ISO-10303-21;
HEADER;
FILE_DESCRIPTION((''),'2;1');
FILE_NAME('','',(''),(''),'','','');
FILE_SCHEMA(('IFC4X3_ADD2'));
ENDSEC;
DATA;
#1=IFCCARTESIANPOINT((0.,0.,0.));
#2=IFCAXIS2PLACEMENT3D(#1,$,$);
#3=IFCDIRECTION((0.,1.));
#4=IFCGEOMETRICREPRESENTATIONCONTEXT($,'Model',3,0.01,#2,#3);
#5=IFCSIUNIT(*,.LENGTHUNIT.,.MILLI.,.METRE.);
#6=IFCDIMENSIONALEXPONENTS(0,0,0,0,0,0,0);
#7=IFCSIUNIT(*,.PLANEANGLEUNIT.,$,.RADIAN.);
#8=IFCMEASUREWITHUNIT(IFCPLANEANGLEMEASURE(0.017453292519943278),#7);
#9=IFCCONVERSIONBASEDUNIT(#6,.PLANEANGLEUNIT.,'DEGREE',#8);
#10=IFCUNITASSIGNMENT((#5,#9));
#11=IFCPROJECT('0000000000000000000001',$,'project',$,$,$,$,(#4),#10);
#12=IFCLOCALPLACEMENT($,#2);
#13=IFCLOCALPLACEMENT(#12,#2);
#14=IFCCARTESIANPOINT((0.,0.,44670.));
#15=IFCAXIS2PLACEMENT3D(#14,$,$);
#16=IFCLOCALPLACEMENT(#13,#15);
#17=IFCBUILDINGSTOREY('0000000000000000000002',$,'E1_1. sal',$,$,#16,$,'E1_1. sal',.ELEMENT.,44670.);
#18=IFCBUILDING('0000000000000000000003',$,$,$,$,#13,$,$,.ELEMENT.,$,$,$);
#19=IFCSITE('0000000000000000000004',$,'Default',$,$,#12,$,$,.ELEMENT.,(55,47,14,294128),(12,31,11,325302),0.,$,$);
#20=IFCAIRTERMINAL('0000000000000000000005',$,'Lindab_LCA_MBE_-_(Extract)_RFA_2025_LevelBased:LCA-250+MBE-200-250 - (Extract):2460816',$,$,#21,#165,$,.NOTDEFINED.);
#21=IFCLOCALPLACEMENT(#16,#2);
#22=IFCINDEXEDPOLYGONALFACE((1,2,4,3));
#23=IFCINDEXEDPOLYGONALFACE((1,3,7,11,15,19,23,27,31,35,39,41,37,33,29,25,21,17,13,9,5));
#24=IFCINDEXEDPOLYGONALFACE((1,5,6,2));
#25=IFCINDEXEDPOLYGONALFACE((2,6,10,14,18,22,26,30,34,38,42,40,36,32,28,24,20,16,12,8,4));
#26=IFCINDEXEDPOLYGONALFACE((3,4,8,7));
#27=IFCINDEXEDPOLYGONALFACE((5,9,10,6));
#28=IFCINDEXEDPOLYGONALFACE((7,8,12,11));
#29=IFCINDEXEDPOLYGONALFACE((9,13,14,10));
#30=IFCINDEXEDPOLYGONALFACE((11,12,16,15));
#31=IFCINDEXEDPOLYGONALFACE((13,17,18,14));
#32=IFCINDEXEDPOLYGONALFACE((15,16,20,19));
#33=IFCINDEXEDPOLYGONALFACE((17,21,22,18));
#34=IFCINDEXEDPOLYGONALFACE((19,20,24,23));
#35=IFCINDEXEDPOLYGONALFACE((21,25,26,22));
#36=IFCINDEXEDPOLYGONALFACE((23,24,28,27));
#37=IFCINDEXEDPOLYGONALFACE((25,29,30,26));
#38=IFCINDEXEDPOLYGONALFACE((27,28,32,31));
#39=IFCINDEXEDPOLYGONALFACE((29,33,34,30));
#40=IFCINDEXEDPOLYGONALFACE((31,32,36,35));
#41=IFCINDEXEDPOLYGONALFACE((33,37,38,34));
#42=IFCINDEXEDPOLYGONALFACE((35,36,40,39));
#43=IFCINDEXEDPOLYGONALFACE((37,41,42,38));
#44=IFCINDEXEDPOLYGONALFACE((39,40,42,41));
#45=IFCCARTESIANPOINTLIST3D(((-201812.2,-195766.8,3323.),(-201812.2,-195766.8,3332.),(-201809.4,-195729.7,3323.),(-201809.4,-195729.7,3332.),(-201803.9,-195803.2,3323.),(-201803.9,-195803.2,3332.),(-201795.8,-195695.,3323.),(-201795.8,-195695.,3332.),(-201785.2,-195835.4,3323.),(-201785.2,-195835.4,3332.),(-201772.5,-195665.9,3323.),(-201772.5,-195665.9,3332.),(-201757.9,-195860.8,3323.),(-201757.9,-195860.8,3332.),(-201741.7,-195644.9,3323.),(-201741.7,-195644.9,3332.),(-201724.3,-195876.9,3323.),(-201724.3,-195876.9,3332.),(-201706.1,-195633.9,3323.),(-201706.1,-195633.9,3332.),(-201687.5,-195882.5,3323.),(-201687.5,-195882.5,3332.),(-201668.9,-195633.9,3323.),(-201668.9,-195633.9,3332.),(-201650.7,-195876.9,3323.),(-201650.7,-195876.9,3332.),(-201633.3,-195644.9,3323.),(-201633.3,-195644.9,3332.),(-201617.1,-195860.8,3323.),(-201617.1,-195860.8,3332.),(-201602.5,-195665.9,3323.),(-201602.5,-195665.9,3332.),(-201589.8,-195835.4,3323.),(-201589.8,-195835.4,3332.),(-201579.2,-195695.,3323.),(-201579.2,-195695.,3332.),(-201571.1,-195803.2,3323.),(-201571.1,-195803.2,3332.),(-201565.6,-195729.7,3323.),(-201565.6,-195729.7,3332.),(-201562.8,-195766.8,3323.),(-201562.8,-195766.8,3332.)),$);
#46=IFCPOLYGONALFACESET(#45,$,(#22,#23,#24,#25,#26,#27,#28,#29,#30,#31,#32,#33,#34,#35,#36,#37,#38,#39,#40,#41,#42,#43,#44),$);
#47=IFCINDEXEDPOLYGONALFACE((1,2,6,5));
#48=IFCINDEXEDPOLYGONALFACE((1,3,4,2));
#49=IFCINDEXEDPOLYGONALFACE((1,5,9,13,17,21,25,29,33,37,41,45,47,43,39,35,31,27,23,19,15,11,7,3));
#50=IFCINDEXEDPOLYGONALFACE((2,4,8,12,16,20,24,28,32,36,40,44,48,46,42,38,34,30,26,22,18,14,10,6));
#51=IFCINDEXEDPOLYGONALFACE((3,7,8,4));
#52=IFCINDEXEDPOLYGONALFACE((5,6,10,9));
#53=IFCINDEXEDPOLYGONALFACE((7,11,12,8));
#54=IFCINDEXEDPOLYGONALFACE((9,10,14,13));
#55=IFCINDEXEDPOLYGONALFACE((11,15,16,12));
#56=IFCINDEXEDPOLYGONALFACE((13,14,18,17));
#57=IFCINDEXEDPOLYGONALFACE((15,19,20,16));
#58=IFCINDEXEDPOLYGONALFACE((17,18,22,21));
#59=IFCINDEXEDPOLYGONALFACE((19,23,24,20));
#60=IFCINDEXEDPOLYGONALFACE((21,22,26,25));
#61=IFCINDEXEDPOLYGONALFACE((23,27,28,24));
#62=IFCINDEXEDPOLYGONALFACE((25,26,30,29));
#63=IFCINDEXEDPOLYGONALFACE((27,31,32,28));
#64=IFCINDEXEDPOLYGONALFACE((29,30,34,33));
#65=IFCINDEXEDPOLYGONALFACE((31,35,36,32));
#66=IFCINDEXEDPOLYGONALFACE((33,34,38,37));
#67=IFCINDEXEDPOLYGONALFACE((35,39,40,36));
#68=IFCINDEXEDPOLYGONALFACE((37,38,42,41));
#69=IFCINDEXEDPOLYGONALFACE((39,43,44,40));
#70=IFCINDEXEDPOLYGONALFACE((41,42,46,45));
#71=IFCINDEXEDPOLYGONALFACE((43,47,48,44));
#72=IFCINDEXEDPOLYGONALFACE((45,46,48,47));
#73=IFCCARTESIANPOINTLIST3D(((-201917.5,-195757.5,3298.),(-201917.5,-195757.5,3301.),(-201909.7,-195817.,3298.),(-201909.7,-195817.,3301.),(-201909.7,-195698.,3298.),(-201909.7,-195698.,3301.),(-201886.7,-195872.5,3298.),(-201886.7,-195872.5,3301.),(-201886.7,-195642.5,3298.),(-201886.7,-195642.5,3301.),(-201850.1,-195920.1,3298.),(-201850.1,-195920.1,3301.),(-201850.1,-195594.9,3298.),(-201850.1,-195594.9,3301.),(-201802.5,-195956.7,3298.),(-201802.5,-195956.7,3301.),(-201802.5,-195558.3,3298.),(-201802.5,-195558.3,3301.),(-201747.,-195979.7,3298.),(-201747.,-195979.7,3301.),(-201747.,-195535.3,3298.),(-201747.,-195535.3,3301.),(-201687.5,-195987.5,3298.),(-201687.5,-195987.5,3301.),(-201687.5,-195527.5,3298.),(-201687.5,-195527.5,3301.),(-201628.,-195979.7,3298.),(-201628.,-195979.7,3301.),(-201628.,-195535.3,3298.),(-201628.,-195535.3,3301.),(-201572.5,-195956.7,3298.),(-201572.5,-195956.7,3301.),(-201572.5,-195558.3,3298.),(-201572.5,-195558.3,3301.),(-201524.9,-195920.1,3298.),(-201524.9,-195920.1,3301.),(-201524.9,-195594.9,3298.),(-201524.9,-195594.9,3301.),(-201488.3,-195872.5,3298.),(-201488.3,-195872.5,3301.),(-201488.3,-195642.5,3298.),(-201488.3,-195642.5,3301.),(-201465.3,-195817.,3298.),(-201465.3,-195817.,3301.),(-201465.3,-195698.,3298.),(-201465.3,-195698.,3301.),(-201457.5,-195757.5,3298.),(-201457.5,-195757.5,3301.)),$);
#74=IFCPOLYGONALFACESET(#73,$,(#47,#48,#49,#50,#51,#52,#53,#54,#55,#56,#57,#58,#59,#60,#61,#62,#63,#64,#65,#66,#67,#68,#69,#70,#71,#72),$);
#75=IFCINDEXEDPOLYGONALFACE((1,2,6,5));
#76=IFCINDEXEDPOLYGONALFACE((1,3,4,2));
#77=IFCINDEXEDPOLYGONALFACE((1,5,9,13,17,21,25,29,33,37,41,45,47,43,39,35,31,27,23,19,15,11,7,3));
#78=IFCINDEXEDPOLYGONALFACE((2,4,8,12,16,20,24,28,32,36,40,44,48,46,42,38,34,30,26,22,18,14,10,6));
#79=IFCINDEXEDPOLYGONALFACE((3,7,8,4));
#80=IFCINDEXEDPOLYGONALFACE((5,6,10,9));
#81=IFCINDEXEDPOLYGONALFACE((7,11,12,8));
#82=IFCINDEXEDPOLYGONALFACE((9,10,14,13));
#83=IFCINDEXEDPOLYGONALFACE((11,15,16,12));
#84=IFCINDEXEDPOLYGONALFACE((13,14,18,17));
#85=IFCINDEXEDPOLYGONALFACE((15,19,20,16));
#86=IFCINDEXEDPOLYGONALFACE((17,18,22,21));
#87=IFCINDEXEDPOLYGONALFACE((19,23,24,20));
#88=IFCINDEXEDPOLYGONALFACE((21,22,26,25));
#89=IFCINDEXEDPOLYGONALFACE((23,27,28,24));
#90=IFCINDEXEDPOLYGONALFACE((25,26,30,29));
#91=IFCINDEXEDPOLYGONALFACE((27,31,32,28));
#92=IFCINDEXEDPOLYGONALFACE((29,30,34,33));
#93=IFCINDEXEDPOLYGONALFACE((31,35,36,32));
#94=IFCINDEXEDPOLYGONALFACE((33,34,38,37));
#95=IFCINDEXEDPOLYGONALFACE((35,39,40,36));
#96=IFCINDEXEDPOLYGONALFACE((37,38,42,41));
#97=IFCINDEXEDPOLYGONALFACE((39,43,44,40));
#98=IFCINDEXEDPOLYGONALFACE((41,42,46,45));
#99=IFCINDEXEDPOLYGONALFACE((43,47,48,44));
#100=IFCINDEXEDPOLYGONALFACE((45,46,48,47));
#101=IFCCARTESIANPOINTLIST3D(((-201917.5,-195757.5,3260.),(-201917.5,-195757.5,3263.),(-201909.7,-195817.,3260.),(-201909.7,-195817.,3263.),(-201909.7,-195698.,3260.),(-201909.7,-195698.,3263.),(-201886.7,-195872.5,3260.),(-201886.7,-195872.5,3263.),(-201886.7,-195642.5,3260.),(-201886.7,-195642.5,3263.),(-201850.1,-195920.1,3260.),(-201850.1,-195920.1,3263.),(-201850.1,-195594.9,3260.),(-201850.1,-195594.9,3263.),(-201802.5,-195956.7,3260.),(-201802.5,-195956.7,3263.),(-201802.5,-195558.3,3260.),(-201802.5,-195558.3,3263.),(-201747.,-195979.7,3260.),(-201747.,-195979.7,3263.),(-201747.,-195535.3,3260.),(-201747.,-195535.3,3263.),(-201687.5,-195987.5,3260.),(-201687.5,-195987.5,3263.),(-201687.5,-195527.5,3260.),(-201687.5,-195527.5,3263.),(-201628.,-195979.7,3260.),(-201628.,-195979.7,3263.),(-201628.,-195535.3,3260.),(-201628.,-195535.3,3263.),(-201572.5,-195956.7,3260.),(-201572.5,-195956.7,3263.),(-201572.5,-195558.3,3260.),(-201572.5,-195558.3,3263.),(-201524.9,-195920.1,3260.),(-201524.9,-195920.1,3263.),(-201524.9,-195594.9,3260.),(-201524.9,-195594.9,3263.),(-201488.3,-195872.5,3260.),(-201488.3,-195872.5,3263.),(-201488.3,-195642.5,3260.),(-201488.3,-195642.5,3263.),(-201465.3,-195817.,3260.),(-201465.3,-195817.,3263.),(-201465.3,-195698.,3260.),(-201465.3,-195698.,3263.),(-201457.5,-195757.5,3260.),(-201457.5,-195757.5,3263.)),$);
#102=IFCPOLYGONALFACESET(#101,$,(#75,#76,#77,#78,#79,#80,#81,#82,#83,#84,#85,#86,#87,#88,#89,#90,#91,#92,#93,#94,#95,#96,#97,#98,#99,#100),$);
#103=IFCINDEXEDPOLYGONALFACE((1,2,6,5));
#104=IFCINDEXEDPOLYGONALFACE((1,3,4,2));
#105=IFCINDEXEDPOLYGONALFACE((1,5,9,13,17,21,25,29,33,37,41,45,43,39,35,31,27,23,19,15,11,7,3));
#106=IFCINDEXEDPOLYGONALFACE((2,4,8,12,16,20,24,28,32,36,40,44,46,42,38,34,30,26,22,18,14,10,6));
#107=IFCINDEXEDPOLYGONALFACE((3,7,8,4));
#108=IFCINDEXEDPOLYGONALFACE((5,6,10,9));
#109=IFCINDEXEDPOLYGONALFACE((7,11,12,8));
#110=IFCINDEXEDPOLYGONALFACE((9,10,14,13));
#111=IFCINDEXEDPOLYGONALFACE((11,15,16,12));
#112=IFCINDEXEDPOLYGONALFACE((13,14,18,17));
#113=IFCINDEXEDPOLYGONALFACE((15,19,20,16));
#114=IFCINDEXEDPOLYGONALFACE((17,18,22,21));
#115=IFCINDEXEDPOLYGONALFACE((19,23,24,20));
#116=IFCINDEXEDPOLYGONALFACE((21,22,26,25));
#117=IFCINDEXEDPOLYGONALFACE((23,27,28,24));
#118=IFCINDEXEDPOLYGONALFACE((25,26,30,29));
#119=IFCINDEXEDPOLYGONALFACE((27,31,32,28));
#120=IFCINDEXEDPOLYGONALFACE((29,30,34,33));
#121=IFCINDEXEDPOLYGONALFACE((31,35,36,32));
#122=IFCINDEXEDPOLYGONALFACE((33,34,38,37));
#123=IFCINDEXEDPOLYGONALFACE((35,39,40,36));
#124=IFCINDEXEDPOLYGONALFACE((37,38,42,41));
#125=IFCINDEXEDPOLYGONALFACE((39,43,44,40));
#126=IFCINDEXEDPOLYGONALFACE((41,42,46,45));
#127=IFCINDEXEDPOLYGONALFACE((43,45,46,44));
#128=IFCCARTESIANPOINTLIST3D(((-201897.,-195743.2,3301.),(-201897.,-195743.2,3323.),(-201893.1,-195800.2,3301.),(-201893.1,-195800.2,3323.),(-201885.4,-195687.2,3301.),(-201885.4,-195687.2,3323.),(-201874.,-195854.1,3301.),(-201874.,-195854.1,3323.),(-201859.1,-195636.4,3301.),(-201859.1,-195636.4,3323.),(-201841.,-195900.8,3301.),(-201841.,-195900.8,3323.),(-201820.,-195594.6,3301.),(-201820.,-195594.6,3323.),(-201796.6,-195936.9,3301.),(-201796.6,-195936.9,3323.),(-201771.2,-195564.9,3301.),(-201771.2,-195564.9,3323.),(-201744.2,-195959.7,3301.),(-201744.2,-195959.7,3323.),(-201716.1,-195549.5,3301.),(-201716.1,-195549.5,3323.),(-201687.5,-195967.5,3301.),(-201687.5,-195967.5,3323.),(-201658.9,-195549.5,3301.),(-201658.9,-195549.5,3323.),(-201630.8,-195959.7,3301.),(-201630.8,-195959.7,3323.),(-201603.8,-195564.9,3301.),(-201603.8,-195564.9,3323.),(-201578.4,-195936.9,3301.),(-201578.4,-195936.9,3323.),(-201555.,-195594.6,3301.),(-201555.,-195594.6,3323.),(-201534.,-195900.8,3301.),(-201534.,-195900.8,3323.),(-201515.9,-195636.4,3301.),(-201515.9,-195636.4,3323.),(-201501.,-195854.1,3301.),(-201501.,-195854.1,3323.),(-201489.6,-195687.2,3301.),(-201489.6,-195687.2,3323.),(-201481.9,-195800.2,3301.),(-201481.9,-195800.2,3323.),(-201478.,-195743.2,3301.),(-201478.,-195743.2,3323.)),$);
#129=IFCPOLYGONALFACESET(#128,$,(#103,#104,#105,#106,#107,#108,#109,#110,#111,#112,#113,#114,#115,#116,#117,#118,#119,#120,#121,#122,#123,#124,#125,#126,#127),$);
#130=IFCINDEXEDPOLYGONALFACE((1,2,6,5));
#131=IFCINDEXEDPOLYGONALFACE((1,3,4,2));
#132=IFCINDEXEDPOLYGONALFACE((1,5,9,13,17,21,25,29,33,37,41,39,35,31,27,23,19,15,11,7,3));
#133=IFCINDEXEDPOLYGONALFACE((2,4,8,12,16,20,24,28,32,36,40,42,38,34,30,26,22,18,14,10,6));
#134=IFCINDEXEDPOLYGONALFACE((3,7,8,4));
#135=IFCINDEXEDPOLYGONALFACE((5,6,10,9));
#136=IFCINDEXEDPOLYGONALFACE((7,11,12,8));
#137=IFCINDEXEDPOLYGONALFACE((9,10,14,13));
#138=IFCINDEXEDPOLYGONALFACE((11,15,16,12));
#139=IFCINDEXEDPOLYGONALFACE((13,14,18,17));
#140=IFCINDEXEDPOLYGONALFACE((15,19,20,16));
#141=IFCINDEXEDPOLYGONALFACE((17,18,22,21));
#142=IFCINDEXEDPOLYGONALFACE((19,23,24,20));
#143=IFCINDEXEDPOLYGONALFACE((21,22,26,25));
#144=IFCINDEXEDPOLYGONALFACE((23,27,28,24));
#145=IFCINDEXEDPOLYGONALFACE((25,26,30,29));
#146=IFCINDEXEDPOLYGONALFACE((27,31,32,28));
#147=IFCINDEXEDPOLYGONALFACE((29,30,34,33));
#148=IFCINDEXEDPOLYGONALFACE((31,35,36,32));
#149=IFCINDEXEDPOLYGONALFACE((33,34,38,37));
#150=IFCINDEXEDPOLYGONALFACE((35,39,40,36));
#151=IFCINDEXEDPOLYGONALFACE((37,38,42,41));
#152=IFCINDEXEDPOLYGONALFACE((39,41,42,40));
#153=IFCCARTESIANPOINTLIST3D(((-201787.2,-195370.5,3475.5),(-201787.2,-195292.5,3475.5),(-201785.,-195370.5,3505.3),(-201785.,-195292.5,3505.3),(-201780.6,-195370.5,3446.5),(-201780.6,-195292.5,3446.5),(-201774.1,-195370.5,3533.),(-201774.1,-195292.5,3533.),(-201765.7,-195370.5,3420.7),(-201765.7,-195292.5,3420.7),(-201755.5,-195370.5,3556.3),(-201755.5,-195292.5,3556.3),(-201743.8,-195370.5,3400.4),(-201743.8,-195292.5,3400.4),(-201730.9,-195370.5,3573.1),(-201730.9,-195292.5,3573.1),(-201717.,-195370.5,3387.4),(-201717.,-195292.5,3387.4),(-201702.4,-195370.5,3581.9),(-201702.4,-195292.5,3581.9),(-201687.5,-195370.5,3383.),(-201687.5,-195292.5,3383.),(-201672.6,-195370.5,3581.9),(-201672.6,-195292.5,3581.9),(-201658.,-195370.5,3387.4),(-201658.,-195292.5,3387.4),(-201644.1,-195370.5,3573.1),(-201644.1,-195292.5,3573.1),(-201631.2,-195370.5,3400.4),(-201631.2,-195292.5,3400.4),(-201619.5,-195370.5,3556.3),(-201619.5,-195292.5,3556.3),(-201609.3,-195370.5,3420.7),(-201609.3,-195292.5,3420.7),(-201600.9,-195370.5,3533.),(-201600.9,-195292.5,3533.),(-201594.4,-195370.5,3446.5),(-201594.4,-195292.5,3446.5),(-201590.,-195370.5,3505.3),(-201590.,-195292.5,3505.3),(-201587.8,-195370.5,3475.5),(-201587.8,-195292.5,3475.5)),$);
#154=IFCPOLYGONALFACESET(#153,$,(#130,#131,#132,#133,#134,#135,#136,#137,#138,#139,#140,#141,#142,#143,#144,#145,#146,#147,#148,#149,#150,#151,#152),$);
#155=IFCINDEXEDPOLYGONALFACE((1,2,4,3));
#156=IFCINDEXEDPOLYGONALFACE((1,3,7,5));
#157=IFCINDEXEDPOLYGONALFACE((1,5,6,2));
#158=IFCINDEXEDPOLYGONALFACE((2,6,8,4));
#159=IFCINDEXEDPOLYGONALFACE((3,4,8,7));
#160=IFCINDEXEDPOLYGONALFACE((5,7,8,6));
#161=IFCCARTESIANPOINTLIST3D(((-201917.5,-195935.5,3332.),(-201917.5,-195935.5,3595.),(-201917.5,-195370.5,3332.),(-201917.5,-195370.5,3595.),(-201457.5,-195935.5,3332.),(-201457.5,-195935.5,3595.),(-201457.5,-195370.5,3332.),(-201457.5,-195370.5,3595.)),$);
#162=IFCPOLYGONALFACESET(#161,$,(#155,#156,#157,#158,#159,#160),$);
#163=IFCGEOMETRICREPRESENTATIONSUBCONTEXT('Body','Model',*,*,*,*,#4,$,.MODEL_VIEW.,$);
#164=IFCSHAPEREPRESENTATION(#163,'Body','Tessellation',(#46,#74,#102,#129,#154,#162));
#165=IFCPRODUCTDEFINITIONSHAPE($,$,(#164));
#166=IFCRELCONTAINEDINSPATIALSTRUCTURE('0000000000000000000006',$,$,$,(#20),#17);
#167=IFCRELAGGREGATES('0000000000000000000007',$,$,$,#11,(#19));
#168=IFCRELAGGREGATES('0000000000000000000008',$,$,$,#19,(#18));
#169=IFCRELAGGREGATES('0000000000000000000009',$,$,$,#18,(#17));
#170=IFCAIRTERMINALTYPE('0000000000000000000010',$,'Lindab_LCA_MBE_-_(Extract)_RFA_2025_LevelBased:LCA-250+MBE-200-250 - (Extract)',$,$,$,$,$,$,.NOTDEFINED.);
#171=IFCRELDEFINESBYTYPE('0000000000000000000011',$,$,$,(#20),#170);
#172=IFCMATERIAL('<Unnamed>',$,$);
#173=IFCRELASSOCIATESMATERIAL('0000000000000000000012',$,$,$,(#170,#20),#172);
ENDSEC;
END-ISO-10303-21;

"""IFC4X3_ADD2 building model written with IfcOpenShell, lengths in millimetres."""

from ifc_helpers import new_model, entity, si_unit, converted_unit, direction, frame, frame_2d, origin, origin_2d_with_axis, place, context, subcontext, project, spatial, rectangle, circle, extrude, source, transform, mapped, material, type_object, type_shapes, element, save


model = new_model("IFC4X3_ADD2")

# Units and contexts
model_context = context("Model", 3, precision=0.01, world=origin(), true_north=direction((0.0, 1.0)))
body_context = subcontext(model_context, "Body", "Model", "MODEL_VIEW")
ifc_project = project(units=[si_unit("LENGTHUNIT", "METRE", prefix="MILLI"), converted_unit("PLANEANGLEUNIT", "DEGREE", entity("IfcPlaneAngleMeasure", 0.017453292519943278), si_unit("PLANEANGLEUNIT", "RADIAN"), dimensions=[0, 0, 0, 0, 0, 0, 0])], contexts=[model_context])

# Site, building, storey
site_placement = place(None, origin())
site = spatial("IfcSite", under=ifc_project, at=site_placement, Name="Default", CompositionType="ELEMENT", RefLatitude=(55, 47, 14, 294128), RefLongitude=(12, 31, 11, 325302), RefElevation=0.0)
building_placement = place(site_placement, origin())
building = spatial("IfcBuilding", under=site, at=building_placement, CompositionType="ELEMENT")
storey_placement = place(building_placement, frame((0.0, 0.0, 44670.0)))
storey = spatial("IfcBuildingStorey", under=building, at=storey_placement, Name="E1_1. sal", LongName="E1_1. sal", CompositionType="ELEMENT", Elevation=44670.0)

# Air terminal
ifc_material_1 = material(Name="<Unnamed>")
air_terminal_type = type_object("IfcAirTerminalType", Name="Lindab_LCA_MBE_-_(Extract)_RFA_2025_LevelBased:LCA-250+MBE-200-250 - (Extract)", PredefinedType="NOTDEFINED", material=ifc_material_1)
shared_shape_1 = source(origin(), body_context, "Body", "SweptSolid", [
    extrude(circle(Radius=125.0, at=frame_2d((0.0, 0.0), x_axis=(1.0, 0.0))), frame((0.0, 0.0, 22.0)), (0.0, 0.0, 1.0), 9.0),
    extrude(circle(Radius=230.0, at=frame_2d((0.0, 0.0), x_axis=(1.0, 0.0))), frame((0.0, 0.0, -3.0)), (0.0, 0.0, 1.0), 3.0),
    extrude(circle(Radius=230.0, at=frame_2d((0.0, 0.0), x_axis=(1.0, 0.0))), frame((0.0, 0.0, -41.0)), (0.0, 0.0, 1.0), 3.0),
    extrude(circle(Radius=210.0, at=frame_2d((0.0, 0.0), x_axis=(1.0, 0.0))), origin(), (0.0, 0.0, 1.0), 22.0),
    extrude(circle(Radius=100.0, at=frame_2d((0.0, 0.0), x_axis=(1.0, 0.0))), frame((-465.0, 0.0, 182.0), z_axis=(1.0, 0.0, 0.0), x_axis=(0.0, 0.0, -1.0)), (0.0, 0.0, 1.0), 78.0),
    extrude(rectangle(XDim=460.0, YDim=565.0, at=origin_2d_with_axis()), frame((-104.5, 0.0, 31.0), z_axis=(0.0, 0.0, 1.0), x_axis=(0.0, -1.0, 0.0)), (0.0, 0.0, 1.0), 263.0),
])
type_shapes(air_terminal_type, [shared_shape_1])
for number, where, z_axis, x_axis, name in (
    (1, (-201687.5, -195757.5, 3301.0), (0.0, 0.0, 1.0), (0.0, -1.0, 0.0), "Lindab_LCA_MBE_-_(Extract)_RFA_2025_LevelBased:LCA-250+MBE-200-250 - (Extract):2460816"),
):
    element("IfcAirTerminal", number, at=place(storey_placement, frame(where, z_axis=z_axis, x_axis=x_axis)), inside=storey, type_object=air_terminal_type, material=ifc_material_1, Name=name, PredefinedType="NOTDEFINED", context=body_context, shape_type="MappedRepresentation", body=[
        mapped(shared_shape_1, transform((0.0, 0.0, 0.0), scale=1.0)),
    ])

save(model, "model.ifc")
